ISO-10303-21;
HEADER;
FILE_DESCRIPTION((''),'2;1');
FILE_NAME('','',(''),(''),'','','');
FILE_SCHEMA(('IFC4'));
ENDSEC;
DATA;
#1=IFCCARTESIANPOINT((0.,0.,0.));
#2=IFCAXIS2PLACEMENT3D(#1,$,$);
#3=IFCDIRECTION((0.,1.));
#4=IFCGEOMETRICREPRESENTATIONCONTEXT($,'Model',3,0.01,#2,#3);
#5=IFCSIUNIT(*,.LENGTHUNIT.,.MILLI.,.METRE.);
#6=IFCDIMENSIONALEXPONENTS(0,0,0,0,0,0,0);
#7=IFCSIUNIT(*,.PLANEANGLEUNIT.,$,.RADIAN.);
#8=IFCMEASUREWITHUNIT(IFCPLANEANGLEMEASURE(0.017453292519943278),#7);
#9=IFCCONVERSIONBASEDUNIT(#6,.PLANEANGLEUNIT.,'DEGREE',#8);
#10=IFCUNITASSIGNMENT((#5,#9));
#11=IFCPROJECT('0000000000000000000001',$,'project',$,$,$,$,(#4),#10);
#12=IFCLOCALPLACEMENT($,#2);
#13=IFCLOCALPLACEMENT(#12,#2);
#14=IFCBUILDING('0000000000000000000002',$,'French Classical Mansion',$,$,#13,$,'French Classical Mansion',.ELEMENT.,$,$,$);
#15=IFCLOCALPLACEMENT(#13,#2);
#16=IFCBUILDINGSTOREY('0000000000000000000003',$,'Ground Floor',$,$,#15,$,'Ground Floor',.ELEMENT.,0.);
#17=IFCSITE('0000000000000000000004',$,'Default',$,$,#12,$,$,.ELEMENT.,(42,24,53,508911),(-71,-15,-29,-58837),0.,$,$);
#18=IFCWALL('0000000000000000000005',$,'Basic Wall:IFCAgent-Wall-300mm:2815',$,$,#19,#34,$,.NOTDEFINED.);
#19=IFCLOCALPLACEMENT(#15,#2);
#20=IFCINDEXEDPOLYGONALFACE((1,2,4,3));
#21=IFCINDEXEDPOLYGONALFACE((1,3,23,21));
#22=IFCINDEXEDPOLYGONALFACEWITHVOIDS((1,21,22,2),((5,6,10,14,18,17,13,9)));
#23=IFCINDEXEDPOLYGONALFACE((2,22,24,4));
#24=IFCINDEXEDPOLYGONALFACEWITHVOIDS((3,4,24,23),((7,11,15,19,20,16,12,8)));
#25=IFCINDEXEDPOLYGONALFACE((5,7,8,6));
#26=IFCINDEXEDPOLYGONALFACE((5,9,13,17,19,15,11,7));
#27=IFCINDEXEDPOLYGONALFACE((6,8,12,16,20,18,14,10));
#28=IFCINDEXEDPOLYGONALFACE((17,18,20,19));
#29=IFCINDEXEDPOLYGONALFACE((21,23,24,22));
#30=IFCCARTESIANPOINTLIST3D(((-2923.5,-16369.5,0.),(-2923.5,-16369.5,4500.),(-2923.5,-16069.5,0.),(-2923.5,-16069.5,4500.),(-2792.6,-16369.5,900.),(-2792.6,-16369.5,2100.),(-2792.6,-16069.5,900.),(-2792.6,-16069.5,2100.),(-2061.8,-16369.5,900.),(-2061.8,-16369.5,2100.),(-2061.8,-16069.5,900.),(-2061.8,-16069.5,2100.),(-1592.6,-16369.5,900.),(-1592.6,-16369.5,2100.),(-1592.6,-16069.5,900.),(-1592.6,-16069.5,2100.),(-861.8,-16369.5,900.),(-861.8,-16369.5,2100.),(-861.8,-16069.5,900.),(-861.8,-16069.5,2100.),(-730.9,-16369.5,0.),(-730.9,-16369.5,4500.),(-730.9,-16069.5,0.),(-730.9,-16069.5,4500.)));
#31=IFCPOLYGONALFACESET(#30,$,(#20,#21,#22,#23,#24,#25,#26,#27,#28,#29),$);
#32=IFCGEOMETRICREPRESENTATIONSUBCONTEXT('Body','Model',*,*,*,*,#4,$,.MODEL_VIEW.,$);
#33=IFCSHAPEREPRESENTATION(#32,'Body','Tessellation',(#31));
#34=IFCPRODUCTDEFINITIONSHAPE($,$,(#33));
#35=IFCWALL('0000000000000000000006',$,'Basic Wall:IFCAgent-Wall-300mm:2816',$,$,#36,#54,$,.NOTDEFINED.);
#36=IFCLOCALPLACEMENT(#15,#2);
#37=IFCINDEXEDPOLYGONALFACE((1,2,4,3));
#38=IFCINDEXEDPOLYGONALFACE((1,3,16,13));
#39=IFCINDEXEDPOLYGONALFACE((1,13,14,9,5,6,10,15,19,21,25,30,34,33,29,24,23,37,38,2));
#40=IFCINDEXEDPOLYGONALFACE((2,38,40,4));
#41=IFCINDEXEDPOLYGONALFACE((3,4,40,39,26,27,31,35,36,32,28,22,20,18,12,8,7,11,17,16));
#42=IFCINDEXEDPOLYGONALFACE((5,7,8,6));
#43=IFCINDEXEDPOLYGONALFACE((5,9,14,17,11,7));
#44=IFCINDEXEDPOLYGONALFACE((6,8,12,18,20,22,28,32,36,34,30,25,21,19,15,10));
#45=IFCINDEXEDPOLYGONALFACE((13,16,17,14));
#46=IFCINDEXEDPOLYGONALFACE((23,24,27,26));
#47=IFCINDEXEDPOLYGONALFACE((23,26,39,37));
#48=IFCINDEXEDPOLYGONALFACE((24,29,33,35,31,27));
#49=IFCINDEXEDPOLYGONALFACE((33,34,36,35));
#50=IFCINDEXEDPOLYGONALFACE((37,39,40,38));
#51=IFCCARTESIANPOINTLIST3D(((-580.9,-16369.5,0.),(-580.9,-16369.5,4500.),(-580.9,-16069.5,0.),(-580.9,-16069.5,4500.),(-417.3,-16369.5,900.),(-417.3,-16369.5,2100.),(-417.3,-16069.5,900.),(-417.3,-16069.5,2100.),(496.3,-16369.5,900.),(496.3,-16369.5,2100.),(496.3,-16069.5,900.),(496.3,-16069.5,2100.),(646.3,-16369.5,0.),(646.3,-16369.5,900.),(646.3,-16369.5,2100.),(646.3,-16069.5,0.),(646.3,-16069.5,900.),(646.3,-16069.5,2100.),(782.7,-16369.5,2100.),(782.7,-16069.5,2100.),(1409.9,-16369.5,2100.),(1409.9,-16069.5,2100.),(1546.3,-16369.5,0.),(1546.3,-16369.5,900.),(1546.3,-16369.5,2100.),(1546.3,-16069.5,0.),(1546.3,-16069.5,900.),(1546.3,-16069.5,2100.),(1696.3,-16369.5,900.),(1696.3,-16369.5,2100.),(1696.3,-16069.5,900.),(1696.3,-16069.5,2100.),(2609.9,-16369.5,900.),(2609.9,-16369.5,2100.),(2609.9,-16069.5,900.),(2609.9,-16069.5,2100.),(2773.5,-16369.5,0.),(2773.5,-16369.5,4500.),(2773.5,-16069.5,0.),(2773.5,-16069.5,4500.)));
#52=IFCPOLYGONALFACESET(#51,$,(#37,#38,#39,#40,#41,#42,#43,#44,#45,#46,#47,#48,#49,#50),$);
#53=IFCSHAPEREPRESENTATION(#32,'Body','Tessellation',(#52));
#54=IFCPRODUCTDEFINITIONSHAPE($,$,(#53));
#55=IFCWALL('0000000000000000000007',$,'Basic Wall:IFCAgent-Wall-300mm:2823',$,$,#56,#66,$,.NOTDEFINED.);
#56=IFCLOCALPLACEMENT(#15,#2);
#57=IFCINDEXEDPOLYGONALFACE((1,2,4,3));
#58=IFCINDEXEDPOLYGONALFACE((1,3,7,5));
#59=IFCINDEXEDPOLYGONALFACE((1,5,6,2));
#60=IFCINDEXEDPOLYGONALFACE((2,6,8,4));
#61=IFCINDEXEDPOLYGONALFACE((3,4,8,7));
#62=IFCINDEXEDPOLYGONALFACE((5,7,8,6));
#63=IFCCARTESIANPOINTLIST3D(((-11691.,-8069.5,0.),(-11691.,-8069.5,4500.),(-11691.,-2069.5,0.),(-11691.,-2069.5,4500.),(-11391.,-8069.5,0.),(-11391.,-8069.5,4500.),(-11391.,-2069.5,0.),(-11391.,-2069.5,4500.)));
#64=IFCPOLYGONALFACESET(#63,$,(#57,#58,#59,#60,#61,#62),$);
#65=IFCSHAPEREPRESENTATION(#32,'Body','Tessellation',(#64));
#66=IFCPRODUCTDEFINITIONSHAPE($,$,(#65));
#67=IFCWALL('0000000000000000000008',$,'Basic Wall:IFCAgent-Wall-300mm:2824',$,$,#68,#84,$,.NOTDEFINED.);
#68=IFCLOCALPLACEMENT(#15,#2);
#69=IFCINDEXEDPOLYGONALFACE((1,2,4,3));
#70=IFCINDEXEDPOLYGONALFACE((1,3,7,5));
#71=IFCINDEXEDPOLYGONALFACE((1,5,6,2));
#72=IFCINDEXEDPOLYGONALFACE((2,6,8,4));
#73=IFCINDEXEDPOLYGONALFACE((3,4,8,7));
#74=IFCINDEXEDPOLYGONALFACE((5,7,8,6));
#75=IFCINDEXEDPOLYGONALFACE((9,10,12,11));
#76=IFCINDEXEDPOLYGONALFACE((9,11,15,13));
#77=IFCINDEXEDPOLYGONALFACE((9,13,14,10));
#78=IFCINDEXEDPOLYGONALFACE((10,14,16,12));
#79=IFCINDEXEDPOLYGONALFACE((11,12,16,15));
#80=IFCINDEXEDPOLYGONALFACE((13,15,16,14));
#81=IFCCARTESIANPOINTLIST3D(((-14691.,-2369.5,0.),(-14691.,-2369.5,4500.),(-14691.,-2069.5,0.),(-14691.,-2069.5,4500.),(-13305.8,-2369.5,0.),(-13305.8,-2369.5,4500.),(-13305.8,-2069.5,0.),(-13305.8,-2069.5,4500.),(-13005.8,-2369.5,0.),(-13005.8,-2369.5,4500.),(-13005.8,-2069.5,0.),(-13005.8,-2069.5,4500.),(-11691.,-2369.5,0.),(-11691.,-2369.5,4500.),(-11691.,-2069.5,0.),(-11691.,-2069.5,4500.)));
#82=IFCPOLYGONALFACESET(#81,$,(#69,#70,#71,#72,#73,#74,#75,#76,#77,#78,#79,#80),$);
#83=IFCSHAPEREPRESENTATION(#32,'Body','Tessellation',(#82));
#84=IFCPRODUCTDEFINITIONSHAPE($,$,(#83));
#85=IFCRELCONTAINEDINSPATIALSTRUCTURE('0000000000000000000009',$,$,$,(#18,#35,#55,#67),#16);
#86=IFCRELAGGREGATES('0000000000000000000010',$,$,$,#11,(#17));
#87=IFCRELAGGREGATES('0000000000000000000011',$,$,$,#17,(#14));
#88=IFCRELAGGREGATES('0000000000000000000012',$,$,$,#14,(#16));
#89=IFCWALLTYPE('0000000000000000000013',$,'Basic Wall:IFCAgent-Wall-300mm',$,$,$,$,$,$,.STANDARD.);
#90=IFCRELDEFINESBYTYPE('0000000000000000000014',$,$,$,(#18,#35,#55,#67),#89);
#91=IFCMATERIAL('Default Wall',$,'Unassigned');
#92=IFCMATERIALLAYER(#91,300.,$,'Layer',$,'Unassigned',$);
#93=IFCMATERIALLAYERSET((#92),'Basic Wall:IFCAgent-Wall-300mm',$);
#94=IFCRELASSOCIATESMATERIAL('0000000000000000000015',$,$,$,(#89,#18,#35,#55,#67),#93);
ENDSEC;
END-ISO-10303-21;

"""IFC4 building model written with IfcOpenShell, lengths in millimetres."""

from ifc_helpers import new_model, entity, si_unit, converted_unit, direction, frame, frame_2d, origin, origin_2d_with_axis, place, context, subcontext, project, spatial, rectangle, extrude, material, layer, layer_set, layer_usage, type_object, element, save


model = new_model("IFC4")

# Units and contexts
model_context = context("Model", 3, precision=0.01, world=origin(), true_north=direction((0.0, 1.0)))
body_context = subcontext(model_context, "Body", "Model", "MODEL_VIEW")
ifc_project = project(units=[si_unit("LENGTHUNIT", "METRE", prefix="MILLI"), converted_unit("PLANEANGLEUNIT", "DEGREE", entity("IfcPlaneAngleMeasure", 0.017453292519943278), si_unit("PLANEANGLEUNIT", "RADIAN"), dimensions=[0, 0, 0, 0, 0, 0, 0])], contexts=[model_context])

# Site, building, storey
site_placement = place(None, origin())
site = spatial("IfcSite", under=ifc_project, at=site_placement, Name="Default", CompositionType="ELEMENT", RefLatitude=(42, 24, 53, 508911), RefLongitude=(-71, -15, -29, -58837), RefElevation=0.0)
building_placement = place(site_placement, origin())
building = spatial("IfcBuilding", under=site, at=building_placement, Name="French Classical Mansion", LongName="French Classical Mansion", CompositionType="ELEMENT")
storey_placement = place(building_placement, origin())
storey = spatial("IfcBuildingStorey", under=building, at=storey_placement, Name="Ground Floor", LongName="Ground Floor", CompositionType="ELEMENT", Elevation=0.0)

# Shared definitions
ifc_material = material(Name="Default Wall", Category="Unassigned")
ifc_layer = layer(ifc_material, 300.0, Name="Layer", Category="Unassigned")
ifc_layer_set = layer_set([ifc_layer], Name="Basic Wall:IFCAgent-Wall-300mm")
wall_type = type_object("IfcWallType", Name="Basic Wall:IFCAgent-Wall-300mm", PredefinedType="STANDARD", material=ifc_layer_set)

# Walls, openings
ifc_layer_usage_1 = layer_usage(ifc_layer_set, "AXIS2", "NEGATIVE", 150.0)
wall_1_placement = place(storey_placement, frame((-2923.5, -16219.5, 0.0)))
wall_1 = element("IfcWall", 1, at=wall_1_placement, inside=storey, type_object=wall_type, material=ifc_layer_usage_1, Name="Basic Wall:IFCAgent-Wall-300mm:2815", PredefinedType="NOTDEFINED", context=body_context, shape_type="SweptSolid", body=[
    extrude(rectangle(XDim=2192.6, YDim=300.0, at=frame_2d((1096.3, 0.0), x_axis=(-1.0, 0.0))), origin(), (0.0, 0.0, 1.0), 4500.0),
])
opening_1_placement = place(wall_1_placement, origin())
element("IfcOpeningElement", 2, at=opening_1_placement, cuts=wall_1, PredefinedType="OPENING", context=body_context, shape_type="SweptSolid", body=[
    extrude(rectangle(XDim=1200.0, YDim=1200.0, at=frame_2d((0.0, 0.0), x_axis=(1.0, 0.0))), frame((730.9, -150.0, 1500.0), z_axis=(0.0, 1.0, 0.0), x_axis=(0.0, 0.0, -1.0)), (0.0, 0.0, 1.0), 300.0),
])
opening_2_placement = place(wall_1_placement, origin())
element("IfcOpeningElement", 3, at=opening_2_placement, cuts=wall_1, PredefinedType="OPENING", context=body_context, shape_type="SweptSolid", body=[
    extrude(rectangle(XDim=1200.0, YDim=1200.0, at=frame_2d((0.0, 0.0), x_axis=(1.0, 0.0))), frame((1461.7, -150.0, 1500.0), z_axis=(0.0, 1.0, 0.0), x_axis=(0.0, 0.0, -1.0)), (0.0, 0.0, 1.0), 300.0),
])
ifc_layer_usage_2 = layer_usage(ifc_layer_set, "AXIS2", "NEGATIVE", 150.0)
wall_2_placement = place(storey_placement, frame((-580.9, -16219.5, 0.0)))
wall_2 = element("IfcWall", 4, at=wall_2_placement, inside=storey, type_object=wall_type, material=ifc_layer_usage_2, Name="Basic Wall:IFCAgent-Wall-300mm:2816", PredefinedType="NOTDEFINED", context=body_context, shape_type="SweptSolid", body=[
    extrude(rectangle(XDim=3354.4, YDim=300.0, at=frame_2d((1677.2, 0.0), x_axis=(-1.0, 0.0))), origin(), (0.0, 0.0, 1.0), 4500.0),
])
opening_3_placement = place(wall_2_placement, origin())
element("IfcOpeningElement", 5, at=opening_3_placement, cuts=wall_2, PredefinedType="OPENING", context=body_context, shape_type="SweptSolid", body=[
    extrude(rectangle(XDim=2100.0, YDim=900.0, at=origin_2d_with_axis()), frame((1677.2, -150.0, 1050.0), z_axis=(0.0, 1.0, 0.0), x_axis=(0.0, 0.0, -1.0)), (0.0, 0.0, 1.0), 300.0),
])
opening_4_placement = place(wall_2_placement, origin())
element("IfcOpeningElement", 6, at=opening_4_placement, cuts=wall_2, PredefinedType="OPENING", context=body_context, shape_type="SweptSolid", body=[
    extrude(rectangle(XDim=1200.0, YDim=1200.0, at=frame_2d((0.0, 0.0), x_axis=(1.0, 0.0))), frame((763.6, -150.0, 1500.0), z_axis=(0.0, 1.0, 0.0), x_axis=(0.0, 0.0, -1.0)), (0.0, 0.0, 1.0), 300.0),
])
opening_5_placement = place(wall_2_placement, origin())
element("IfcOpeningElement", 7, at=opening_5_placement, cuts=wall_2, PredefinedType="OPENING", context=body_context, shape_type="SweptSolid", body=[
    extrude(rectangle(XDim=1200.0, YDim=1200.0, at=frame_2d((0.0, 0.0), x_axis=(1.0, 0.0))), frame((1677.2, -150.0, 1500.0), z_axis=(0.0, 1.0, 0.0), x_axis=(0.0, 0.0, -1.0)), (0.0, 0.0, 1.0), 300.0),
])
opening_6_placement = place(wall_2_placement, origin())
element("IfcOpeningElement", 8, at=opening_6_placement, cuts=wall_2, PredefinedType="OPENING", context=body_context, shape_type="SweptSolid", body=[
    extrude(rectangle(XDim=1200.0, YDim=1200.0, at=frame_2d((0.0, 0.0), x_axis=(1.0, 0.0))), frame((2590.8, -150.0, 1500.0), z_axis=(0.0, 1.0, 0.0), x_axis=(0.0, 0.0, -1.0)), (0.0, 0.0, 1.0), 300.0),
])

# Wall
ifc_layer_usage_3 = layer_usage(ifc_layer_set, "AXIS2", "NEGATIVE", 150.0)
wall_3_placement = place(storey_placement, frame((-11541.0, -8069.5, 0.0), z_axis=(0.0, 0.0, 1.0), x_axis=(0.0, 1.0, 0.0)))
element("IfcWall", 9, at=wall_3_placement, inside=storey, type_object=wall_type, material=ifc_layer_usage_3, Name="Basic Wall:IFCAgent-Wall-300mm:2823", PredefinedType="NOTDEFINED", context=body_context, shape_type="SweptSolid", body=[
    extrude(rectangle(XDim=6000.0, YDim=300.0, at=frame_2d((3000.0, 0.0), x_axis=(-1.0, 0.0))), origin(), (0.0, 0.0, 1.0), 4500.0),
])

# Wall, opening
ifc_layer_usage_4 = layer_usage(ifc_layer_set, "AXIS2", "NEGATIVE", 150.0)
wall_4_placement = place(storey_placement, frame((-11691.0, -2219.5, 0.0), z_axis=(0.0, 0.0, 1.0), x_axis=(-1.0, 0.0, 0.0)))
wall_4 = element("IfcWall", 10, at=wall_4_placement, inside=storey, type_object=wall_type, material=ifc_layer_usage_4, Name="Basic Wall:IFCAgent-Wall-300mm:2824", PredefinedType="NOTDEFINED", context=body_context, shape_type="SweptSolid", body=[
    extrude(rectangle(XDim=3000.0, YDim=300.0, at=frame_2d((1500.0, 0.0), x_axis=(-1.0, 0.0))), origin(), (0.0, 0.0, 1.0), 4500.0),
])
opening_7_placement = place(storey_placement, frame((-11691.0, -2219.5, 0.0), z_axis=(0.0, 0.0, 1.0), x_axis=(-1.0, 0.0, 0.0)))
element("IfcOpeningElement", 11, at=opening_7_placement, cuts=wall_4, PredefinedType="OPENING", context=body_context, shape_type="SweptSolid", body=[
    extrude(rectangle(XDim=4500.0, YDim=300.0, at=origin_2d_with_axis()), frame((1614.8, 0.0, 2250.0), z_axis=(-1.0, 0.0, 0.0), x_axis=(0.0, 0.0, 1.0)), (0.0, 0.0, 1.0), 300.0),
])

save(model, "model.ifc")
